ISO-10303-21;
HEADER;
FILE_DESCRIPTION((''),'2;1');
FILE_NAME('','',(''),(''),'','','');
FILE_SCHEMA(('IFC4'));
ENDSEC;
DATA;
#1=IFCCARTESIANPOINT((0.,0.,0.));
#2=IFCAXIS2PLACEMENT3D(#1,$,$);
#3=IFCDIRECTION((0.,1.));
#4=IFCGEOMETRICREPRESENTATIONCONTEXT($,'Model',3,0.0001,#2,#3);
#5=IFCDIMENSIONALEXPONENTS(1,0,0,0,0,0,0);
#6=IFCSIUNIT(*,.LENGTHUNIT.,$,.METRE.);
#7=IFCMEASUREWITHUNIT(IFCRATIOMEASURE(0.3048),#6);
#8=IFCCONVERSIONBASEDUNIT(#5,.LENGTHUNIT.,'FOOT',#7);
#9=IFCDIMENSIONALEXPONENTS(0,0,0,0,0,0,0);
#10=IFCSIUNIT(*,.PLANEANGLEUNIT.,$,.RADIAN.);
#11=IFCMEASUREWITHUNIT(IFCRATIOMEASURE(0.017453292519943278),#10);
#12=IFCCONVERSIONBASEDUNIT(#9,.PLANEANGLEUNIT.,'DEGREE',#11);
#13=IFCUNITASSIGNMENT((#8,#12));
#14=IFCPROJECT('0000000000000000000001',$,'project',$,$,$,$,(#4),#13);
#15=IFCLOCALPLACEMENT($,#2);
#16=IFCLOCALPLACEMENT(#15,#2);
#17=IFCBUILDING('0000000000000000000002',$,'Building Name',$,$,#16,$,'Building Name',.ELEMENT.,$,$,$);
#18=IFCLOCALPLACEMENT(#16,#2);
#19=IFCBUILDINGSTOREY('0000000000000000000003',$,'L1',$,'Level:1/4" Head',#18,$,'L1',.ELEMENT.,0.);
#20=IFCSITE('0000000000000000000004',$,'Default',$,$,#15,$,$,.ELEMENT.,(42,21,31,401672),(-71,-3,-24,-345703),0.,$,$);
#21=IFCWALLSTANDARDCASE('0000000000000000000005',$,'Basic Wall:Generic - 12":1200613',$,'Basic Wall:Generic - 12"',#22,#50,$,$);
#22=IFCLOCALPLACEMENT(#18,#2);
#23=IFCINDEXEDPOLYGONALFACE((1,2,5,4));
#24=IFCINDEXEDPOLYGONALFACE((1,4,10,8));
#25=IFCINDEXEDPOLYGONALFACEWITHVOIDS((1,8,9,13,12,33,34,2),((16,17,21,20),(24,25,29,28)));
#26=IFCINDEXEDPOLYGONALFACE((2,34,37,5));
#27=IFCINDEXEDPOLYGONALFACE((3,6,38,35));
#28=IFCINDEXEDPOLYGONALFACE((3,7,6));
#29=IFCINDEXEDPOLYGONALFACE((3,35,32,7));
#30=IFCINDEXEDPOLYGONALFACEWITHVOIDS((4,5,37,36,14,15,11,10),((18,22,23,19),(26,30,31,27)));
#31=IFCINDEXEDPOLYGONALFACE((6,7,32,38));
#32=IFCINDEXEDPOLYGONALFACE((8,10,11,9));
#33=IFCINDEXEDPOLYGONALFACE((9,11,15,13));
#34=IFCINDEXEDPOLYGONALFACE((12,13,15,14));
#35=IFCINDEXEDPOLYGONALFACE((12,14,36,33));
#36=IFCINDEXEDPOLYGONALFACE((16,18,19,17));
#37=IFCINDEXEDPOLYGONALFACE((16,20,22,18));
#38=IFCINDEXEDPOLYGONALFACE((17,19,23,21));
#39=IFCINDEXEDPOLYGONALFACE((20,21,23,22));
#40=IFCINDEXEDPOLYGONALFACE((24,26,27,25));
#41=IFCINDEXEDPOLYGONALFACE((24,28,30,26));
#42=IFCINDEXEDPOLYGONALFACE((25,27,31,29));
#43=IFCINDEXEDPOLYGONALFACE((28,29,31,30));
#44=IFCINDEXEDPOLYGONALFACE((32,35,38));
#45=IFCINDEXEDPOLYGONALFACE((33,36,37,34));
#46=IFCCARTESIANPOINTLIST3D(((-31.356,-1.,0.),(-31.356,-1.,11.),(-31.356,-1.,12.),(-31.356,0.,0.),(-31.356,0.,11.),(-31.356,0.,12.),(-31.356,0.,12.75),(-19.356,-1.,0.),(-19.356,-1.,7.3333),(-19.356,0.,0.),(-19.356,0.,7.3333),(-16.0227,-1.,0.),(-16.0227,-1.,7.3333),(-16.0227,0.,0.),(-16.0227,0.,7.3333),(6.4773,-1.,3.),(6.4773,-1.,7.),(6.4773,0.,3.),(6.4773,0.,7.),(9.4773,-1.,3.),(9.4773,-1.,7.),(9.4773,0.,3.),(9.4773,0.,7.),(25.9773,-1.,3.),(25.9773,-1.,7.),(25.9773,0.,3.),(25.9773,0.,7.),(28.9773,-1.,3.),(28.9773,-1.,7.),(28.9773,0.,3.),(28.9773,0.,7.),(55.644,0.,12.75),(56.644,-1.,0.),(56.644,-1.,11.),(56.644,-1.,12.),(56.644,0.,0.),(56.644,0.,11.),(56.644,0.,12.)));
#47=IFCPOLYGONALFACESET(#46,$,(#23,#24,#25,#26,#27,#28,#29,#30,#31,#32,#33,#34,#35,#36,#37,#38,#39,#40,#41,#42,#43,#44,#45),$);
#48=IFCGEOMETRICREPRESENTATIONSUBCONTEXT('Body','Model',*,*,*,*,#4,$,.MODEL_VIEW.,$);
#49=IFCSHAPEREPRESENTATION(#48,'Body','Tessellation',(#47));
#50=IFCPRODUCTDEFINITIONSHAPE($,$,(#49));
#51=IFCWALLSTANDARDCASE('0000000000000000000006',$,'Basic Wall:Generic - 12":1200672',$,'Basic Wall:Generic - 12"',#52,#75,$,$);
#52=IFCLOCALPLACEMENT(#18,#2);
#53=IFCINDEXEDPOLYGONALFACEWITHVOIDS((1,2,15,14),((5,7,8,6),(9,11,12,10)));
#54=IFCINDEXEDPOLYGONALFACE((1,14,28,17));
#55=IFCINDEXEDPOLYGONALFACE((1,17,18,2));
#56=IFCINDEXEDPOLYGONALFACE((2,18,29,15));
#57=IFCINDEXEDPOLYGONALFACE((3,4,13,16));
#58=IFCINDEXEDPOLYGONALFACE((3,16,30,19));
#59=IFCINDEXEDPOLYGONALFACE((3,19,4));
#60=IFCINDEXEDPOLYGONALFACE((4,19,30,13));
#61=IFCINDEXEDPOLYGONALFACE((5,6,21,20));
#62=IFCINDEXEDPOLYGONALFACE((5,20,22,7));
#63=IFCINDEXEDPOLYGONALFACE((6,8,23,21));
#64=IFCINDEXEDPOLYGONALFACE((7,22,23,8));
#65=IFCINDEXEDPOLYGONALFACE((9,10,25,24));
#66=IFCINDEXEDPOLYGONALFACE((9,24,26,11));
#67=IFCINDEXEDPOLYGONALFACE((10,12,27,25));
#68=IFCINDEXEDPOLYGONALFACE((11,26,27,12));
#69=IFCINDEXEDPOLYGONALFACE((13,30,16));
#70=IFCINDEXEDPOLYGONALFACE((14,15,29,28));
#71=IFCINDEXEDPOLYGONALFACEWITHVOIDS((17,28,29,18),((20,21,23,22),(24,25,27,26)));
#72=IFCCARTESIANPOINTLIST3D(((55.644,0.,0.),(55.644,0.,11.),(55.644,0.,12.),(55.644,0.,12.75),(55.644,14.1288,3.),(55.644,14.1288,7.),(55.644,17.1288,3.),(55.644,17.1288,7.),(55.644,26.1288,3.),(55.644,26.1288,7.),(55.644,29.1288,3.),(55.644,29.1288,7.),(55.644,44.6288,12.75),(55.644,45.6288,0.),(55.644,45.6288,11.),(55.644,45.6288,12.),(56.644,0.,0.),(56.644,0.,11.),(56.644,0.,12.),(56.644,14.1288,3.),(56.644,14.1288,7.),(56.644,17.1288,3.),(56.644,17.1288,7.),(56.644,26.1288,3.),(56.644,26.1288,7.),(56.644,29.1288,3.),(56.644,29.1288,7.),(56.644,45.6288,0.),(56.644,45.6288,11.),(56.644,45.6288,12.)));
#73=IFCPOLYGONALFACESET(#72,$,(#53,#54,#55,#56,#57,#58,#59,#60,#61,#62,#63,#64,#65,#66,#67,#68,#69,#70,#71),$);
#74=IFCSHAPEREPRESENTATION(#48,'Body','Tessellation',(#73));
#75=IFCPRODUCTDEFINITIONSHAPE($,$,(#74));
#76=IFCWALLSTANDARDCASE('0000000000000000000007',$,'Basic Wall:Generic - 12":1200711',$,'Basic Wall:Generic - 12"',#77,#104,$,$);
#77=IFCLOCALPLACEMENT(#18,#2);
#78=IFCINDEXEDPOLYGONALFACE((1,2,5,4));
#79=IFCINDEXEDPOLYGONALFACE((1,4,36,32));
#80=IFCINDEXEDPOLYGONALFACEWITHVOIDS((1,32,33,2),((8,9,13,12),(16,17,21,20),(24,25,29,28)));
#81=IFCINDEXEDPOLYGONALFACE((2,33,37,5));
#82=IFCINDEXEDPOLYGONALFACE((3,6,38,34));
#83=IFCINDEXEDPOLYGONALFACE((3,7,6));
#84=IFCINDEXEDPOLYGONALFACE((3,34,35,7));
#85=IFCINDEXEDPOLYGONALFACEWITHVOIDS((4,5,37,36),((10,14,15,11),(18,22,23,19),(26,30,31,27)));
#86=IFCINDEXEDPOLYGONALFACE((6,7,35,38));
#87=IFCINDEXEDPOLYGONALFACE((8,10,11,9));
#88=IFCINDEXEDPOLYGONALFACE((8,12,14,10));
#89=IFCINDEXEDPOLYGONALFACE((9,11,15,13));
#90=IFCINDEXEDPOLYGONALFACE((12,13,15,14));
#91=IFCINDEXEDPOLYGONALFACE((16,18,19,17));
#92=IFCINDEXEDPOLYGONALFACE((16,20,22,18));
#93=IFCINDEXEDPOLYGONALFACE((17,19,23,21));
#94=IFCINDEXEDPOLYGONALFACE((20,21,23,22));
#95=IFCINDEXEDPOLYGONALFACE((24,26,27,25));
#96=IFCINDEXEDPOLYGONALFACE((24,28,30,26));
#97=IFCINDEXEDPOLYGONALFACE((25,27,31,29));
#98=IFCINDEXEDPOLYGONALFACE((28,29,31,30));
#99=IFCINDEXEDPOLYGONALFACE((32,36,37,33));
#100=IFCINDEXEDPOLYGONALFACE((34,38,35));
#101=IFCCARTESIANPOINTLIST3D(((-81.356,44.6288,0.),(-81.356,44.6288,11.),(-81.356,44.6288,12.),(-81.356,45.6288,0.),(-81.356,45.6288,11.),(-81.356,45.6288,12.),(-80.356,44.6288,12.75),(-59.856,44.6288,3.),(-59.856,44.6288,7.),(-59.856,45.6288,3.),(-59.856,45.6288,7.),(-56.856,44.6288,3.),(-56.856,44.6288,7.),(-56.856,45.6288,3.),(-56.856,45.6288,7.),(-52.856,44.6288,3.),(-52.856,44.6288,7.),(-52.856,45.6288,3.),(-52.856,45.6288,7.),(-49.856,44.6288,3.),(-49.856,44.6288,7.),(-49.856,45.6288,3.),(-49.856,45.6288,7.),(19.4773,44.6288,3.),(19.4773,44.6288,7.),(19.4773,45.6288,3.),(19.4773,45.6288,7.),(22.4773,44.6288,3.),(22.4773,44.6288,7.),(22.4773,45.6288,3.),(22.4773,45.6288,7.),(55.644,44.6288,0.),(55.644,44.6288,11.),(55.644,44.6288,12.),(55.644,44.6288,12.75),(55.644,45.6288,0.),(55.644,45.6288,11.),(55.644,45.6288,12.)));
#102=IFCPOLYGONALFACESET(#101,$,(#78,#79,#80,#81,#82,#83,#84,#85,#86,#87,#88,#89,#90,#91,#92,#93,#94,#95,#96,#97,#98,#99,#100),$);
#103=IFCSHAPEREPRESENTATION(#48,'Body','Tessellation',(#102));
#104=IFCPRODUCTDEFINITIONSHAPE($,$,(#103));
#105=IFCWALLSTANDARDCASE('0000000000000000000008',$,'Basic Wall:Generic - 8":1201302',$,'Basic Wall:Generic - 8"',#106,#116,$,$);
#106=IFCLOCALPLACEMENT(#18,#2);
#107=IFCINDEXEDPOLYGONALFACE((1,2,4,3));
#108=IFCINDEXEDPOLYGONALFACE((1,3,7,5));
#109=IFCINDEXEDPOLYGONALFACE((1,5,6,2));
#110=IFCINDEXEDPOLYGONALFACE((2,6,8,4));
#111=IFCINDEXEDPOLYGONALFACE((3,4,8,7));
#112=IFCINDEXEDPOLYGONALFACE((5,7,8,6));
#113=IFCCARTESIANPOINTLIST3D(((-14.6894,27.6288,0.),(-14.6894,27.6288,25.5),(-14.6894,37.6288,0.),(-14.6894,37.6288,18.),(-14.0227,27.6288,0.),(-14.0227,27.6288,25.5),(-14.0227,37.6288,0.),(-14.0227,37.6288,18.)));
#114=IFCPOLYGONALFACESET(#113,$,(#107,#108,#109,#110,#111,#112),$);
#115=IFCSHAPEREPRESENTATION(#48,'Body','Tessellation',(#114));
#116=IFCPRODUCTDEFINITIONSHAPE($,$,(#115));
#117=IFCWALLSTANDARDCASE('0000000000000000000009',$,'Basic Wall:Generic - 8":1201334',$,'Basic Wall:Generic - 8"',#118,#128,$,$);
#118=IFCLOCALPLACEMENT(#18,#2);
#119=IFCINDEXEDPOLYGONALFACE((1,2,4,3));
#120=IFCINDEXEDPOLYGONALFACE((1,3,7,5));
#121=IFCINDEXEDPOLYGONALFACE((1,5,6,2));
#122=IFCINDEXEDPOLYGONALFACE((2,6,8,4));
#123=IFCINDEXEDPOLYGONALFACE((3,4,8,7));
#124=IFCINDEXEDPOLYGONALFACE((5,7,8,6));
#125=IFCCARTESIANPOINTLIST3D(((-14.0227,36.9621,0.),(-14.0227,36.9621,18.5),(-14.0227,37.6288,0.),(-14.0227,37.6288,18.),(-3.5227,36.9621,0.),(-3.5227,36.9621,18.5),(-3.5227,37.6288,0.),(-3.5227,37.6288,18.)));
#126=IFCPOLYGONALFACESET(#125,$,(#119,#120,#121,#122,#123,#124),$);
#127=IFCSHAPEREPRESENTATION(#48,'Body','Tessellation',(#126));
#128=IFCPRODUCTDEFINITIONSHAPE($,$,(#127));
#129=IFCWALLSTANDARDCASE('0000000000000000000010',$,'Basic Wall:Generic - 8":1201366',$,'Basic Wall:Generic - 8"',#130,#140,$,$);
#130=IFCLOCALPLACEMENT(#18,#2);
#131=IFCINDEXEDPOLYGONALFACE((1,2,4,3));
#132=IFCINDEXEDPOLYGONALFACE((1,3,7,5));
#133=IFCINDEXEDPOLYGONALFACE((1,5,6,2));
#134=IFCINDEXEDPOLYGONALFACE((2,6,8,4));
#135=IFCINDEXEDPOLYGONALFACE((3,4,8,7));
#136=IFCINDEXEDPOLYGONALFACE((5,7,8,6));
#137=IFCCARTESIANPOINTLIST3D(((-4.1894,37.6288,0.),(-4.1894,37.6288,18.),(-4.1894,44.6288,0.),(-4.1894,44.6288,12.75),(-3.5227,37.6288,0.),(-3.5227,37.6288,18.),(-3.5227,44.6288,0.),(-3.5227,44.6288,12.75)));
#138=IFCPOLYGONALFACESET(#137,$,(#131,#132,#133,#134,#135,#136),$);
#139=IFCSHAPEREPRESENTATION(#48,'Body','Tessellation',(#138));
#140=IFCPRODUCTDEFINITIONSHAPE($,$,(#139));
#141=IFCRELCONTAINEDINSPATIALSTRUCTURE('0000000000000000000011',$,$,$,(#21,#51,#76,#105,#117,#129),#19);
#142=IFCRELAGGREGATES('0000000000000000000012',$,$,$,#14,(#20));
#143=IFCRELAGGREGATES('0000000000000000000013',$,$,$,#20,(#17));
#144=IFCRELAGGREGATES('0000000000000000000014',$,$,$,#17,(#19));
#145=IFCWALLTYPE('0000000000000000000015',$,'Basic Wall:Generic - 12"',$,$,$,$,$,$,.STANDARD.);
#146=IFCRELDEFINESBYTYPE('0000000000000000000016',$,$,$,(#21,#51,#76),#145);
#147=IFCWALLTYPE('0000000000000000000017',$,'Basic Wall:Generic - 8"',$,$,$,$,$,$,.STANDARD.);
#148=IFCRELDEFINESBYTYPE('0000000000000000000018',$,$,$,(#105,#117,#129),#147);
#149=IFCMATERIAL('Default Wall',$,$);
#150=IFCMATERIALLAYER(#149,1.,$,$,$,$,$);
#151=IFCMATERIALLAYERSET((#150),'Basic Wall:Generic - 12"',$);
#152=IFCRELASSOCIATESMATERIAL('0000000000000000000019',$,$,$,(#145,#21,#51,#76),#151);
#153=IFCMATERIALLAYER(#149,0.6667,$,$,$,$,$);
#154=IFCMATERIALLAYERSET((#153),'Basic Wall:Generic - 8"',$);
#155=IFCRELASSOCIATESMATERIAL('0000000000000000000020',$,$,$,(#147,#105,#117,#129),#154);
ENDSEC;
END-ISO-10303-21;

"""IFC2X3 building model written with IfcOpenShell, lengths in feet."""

from ifc_helpers import new_model, entity, si_unit, converted_unit, direction, frame, frame_2d, origin, place, context, subcontext, project, spatial, polyline, rectangle, extrude, clip, bounded_halfspace, material, layer, layer_set, layer_usage, type_object, element, save


model = new_model("IFC2X3")

# Units and contexts
model_context = context("Model", 3, precision=0.0001, world=origin(), true_north=direction((0.0, 1.0)))
body_context = subcontext(model_context, "Body", "Model", "MODEL_VIEW")
ifc_project = project(units=[converted_unit("LENGTHUNIT", "FOOT", entity("IfcRatioMeasure", 0.3048), si_unit("LENGTHUNIT", "METRE"), dimensions=[1, 0, 0, 0, 0, 0, 0]), converted_unit("PLANEANGLEUNIT", "DEGREE", entity("IfcRatioMeasure", 0.017453292519943278), si_unit("PLANEANGLEUNIT", "RADIAN"), dimensions=[0, 0, 0, 0, 0, 0, 0])], contexts=[model_context])

# Site, building, storey
site_placement = place(None, origin())
site = spatial("IfcSite", under=ifc_project, at=site_placement, Name="Default", CompositionType="ELEMENT", RefLatitude=(42, 21, 31, 401672), RefLongitude=(-71, -3, -24, -345703), RefElevation=0.0)
building_placement = place(site_placement, origin())
building = spatial("IfcBuilding", under=site, at=building_placement, Name="Building Name", LongName="Building Name", CompositionType="ELEMENT")
storey_placement = place(building_placement, origin())
storey = spatial("IfcBuildingStorey", under=building, at=storey_placement, Name="L1", ObjectType="Level:1/4\" Head", LongName="L1", CompositionType="ELEMENT", Elevation=0.0)

# Walls, openings
ifc_material_1 = material(Name="Default Wall")
ifc_layer_1 = layer(ifc_material_1, 1.0)
ifc_layer_set_1 = layer_set([ifc_layer_1], Name="Basic Wall:Generic - 12\"")
ifc_layer_usage_1 = layer_usage(ifc_layer_set_1, "AXIS2", "NEGATIVE", 0.5)
wall_type_1 = type_object("IfcWallType", Name="Basic Wall:Generic - 12\"", PredefinedType="STANDARD", material=ifc_layer_set_1)
wall_1_placement = place(storey_placement, frame((-31.356, -0.5, 0.0)))
wall_1 = element("IfcWallStandardCase", 1, at=wall_1_placement, inside=storey, type_object=wall_type_1, material=ifc_layer_usage_1, Name="Basic Wall:Generic - 12\":1200613", ObjectType="Basic Wall:Generic - 12\"", context=body_context, shape_type="Clipping", body=[
    clip(clip(extrude(rectangle(XDim=1.0, YDim=88.0, at=frame_2d((44.0, 0.0), x_axis=(0.0, 1.0))), origin(), (0.0, 0.0, 1.0), 12.75), bounded_halfspace(frame((0.0, 0.5, 12.75), z_axis=(0.0, -0.6, 0.8), x_axis=(1.0, 0.0, 0.0)), False, frame((0.0, 0.5, 12.75)), polyline([(0.0, 0.0), (0.0, -1.0), (88.0, -1.0), (87.0, 0.0), (0.0, 0.0)]))), bounded_halfspace(frame((88.0, 0.5, 12.0), z_axis=(0.6, 0.0, 0.8), x_axis=(0.0, 1.0, 0.0)), False, frame((88.0, 0.5, 12.0)), polyline([(0.0, 0.0), (-1.0, 0.0), (0.0, -1.0), (0.0, 0.0)]))),
])
opening_1_placement = place(storey_placement, frame((-31.356, -0.5, 0.0)))
element("IfcOpeningElement", 2, at=opening_1_placement, cuts=wall_1, ObjectType="Opening", context=body_context, shape_type="SweptSolid", body=[
    extrude(rectangle(XDim=88.0, YDim=1.0, at=frame_2d((-8.6, -0.1), x_axis=(1.0, 0.0))), frame((52.6, 0.1, 11.0)), (0.0, 0.0, 1.0), 1.0),
])
opening_2_placement = place(wall_1_placement, frame((12.0, -0.5, 0.0)))
element("IfcOpeningElement", 3, at=opening_2_placement, cuts=wall_1, ObjectType="Opening", context=body_context, shape_type="SweptSolid", body=[
    extrude(rectangle(XDim=7.3333, YDim=3.3333, at=frame_2d((3.6667, 1.6667), x_axis=(1.0, 0.0))), frame((0.0, 0.0, 0.0), z_axis=(0.0, 1.0, 0.0), x_axis=(0.0, 0.0, 1.0)), (0.0, 0.0, 1.0), 1.0),
])
opening_3_placement = place(wall_1_placement, frame((37.8333, -0.5, 3.0)))
element("IfcOpeningElement", 4, at=opening_3_placement, cuts=wall_1, ObjectType="Opening", context=body_context, shape_type="SweptSolid", body=[
    extrude(rectangle(XDim=4.0, YDim=3.0, at=frame_2d((2.0, 1.5), x_axis=(-1.0, 0.0))), frame((0.0, 0.0, 0.0), z_axis=(0.0, 1.0, 0.0), x_axis=(0.0, 0.0, 1.0)), (0.0, 0.0, 1.0), 1.0),
])
opening_4_placement = place(wall_1_placement, frame((60.3333, 0.5, 3.0)))
element("IfcOpeningElement", 5, at=opening_4_placement, cuts=wall_1, ObjectType="Opening", context=body_context, shape_type="SweptSolid", body=[
    extrude(rectangle(XDim=4.0, YDim=3.0, at=frame_2d((2.0, 1.5), x_axis=(-1.0, 0.0))), frame((0.0, 0.0, 0.0), z_axis=(0.0, -1.0, 0.0), x_axis=(0.0, 0.0, 1.0)), (0.0, 0.0, 1.0), 1.0),
])
wall_2_placement = place(storey_placement, frame((56.144, 0.0, 0.0), z_axis=(0.0, 0.0, 1.0), x_axis=(0.0, 1.0, 0.0)))
wall_2 = element("IfcWallStandardCase", 6, at=wall_2_placement, inside=storey, type_object=wall_type_1, material=ifc_layer_usage_1, Name="Basic Wall:Generic - 12\":1200672", ObjectType="Basic Wall:Generic - 12\"", context=body_context, shape_type="Clipping", body=[
    clip(clip(extrude(rectangle(XDim=45.6288, YDim=1.0, at=frame_2d((22.8144, 0.0), x_axis=(-1.0, 0.0))), origin(), (0.0, 0.0, 1.0), 12.75), bounded_halfspace(frame((0.0, 0.5, 12.75), z_axis=(0.0, -0.6, 0.8), x_axis=(1.0, 0.0, 0.0)), False, frame((0.0, 0.5, 12.75)), polyline([(0.0, 0.0), (0.0, -1.0), (45.6288, -1.0), (44.6288, 0.0), (0.0, 0.0)]))), bounded_halfspace(frame((45.6288, 0.5, 12.0), z_axis=(0.6, 0.0, 0.8), x_axis=(0.0, 1.0, 0.0)), False, frame((45.6288, 0.5, 12.0)), polyline([(0.0, 0.0), (-1.0, 0.0), (0.0, -1.0), (0.0, 0.0)]))),
])
opening_5_placement = place(storey_placement, frame((56.144, 0.0, 0.0), z_axis=(0.0, 0.0, 1.0), x_axis=(0.0, 1.0, 0.0)))
element("IfcOpeningElement", 7, at=opening_5_placement, cuts=wall_2, ObjectType="Opening", context=body_context, shape_type="SweptSolid", body=[
    extrude(rectangle(XDim=45.6288, YDim=1.0, at=frame_2d((-4.3629, -0.1), x_axis=(1.0, 0.0))), frame((27.1773, 0.1, 11.0)), (0.0, 0.0, 1.0), 1.0),
])
opening_6_placement = place(wall_2_placement, frame((29.1288, 0.5, 3.0)))
element("IfcOpeningElement", 8, at=opening_6_placement, cuts=wall_2, ObjectType="Opening", context=body_context, shape_type="SweptSolid", body=[
    extrude(rectangle(XDim=4.0, YDim=3.0, at=frame_2d((2.0, 1.5), x_axis=(-1.0, 0.0))), frame((0.0, 0.0, 0.0), z_axis=(0.0, -1.0, 0.0), x_axis=(0.0, 0.0, 1.0)), (0.0, 0.0, 1.0), 1.0),
])
opening_7_placement = place(wall_2_placement, frame((14.1288, -0.5, 3.0)))
element("IfcOpeningElement", 9, at=opening_7_placement, cuts=wall_2, ObjectType="Opening", context=body_context, shape_type="SweptSolid", body=[
    extrude(rectangle(XDim=4.0, YDim=3.0, at=frame_2d((2.0, 1.5), x_axis=(-1.0, 0.0))), frame((0.0, 0.0, 0.0), z_axis=(0.0, 1.0, 0.0), x_axis=(0.0, 0.0, 1.0)), (0.0, 0.0, 1.0), 1.0),
])
wall_3_placement = place(storey_placement, frame((55.644, 45.1288, 0.0), z_axis=(0.0, 0.0, 1.0), x_axis=(-1.0, 0.0, 0.0)))
wall_3 = element("IfcWallStandardCase", 10, at=wall_3_placement, inside=storey, type_object=wall_type_1, material=ifc_layer_usage_1, Name="Basic Wall:Generic - 12\":1200711", ObjectType="Basic Wall:Generic - 12\"", context=body_context, shape_type="Clipping", body=[
    clip(clip(extrude(rectangle(XDim=137.0, YDim=1.0, at=frame_2d((68.5, 0.0), x_axis=(-1.0, 0.0))), origin(), (0.0, 0.0, 1.0), 12.75), bounded_halfspace(frame((137.0, 0.5, 12.0), z_axis=(0.6, 0.0, 0.8), x_axis=(0.0, 1.0, 0.0)), False, frame((137.0, 0.5, 12.0)), polyline([(0.0, 0.0), (-1.0, 0.0), (0.0, -1.0), (0.0, 0.0)]))), bounded_halfspace(frame((0.0, 0.5, 12.75), z_axis=(0.0, -0.6, 0.8), x_axis=(1.0, 0.0, 0.0)), False, frame((0.0, 0.5, 12.75)), polyline([(0.0, 0.0), (0.0, -1.0), (137.0, -1.0), (136.0, 0.0), (88.0, 0.0), (87.3333, 0.0), (59.8333, 0.0), (59.1667, 0.0), (0.0, 0.0)]))),
])
opening_8_placement = place(storey_placement, frame((55.644, 45.1288, 0.0), z_axis=(0.0, 0.0, 1.0), x_axis=(-1.0, 0.0, 0.0)))
element("IfcOpeningElement", 11, at=opening_8_placement, cuts=wall_3, ObjectType="Opening", context=body_context, shape_type="SweptSolid", body=[
    extrude(rectangle(XDim=137.0, YDim=1.0, at=frame_2d((-13.5, -0.1), x_axis=(1.0, 0.0))), frame((82.0, 0.1, 11.0)), (0.0, 0.0, 1.0), 1.0),
])
opening_9_placement = place(wall_3_placement, frame((33.1667, -0.5, 3.0)))
element("IfcOpeningElement", 12, at=opening_9_placement, cuts=wall_3, ObjectType="Opening", context=body_context, shape_type="SweptSolid", body=[
    extrude(rectangle(XDim=4.0, YDim=3.0, at=frame_2d((2.0, 1.5), x_axis=(-1.0, 0.0))), frame((0.0, 0.0, 0.0), z_axis=(0.0, 1.0, 0.0), x_axis=(0.0, 0.0, 1.0)), (0.0, 0.0, 1.0), 1.0),
])
opening_10_placement = place(wall_3_placement, frame((105.5, -0.5, 3.0)))
element("IfcOpeningElement", 13, at=opening_10_placement, cuts=wall_3, ObjectType="Opening", context=body_context, shape_type="SweptSolid", body=[
    extrude(rectangle(XDim=4.0, YDim=3.0, at=frame_2d((2.0, 1.5), x_axis=(-1.0, 0.0))), frame((0.0, 0.0, 0.0), z_axis=(0.0, 1.0, 0.0), x_axis=(0.0, 0.0, 1.0)), (0.0, 0.0, 1.0), 1.0),
])
opening_11_placement = place(wall_3_placement, frame((112.5, -0.5, 3.0)))
element("IfcOpeningElement", 14, at=opening_11_placement, cuts=wall_3, ObjectType="Opening", context=body_context, shape_type="SweptSolid", body=[
    extrude(rectangle(XDim=4.0, YDim=3.0, at=frame_2d((2.0, 1.5), x_axis=(-1.0, 0.0))), frame((0.0, 0.0, 0.0), z_axis=(0.0, 1.0, 0.0), x_axis=(0.0, 0.0, 1.0)), (0.0, 0.0, 1.0), 1.0),
])

# Walls
ifc_layer_2 = layer(ifc_material_1, 0.6667)
ifc_layer_set_2 = layer_set([ifc_layer_2], Name="Basic Wall:Generic - 8\"")
ifc_layer_usage_2 = layer_usage(ifc_layer_set_2, "AXIS2", "NEGATIVE", 0.3333)
wall_type_2 = type_object("IfcWallType", Name="Basic Wall:Generic - 8\"", PredefinedType="STANDARD", material=ifc_layer_set_2)
wall_4_placement = place(storey_placement, frame((-14.356, 27.6288, 0.0), z_axis=(0.0, 0.0, 1.0), x_axis=(0.0, 1.0, 0.0)))
element("IfcWallStandardCase", 15, at=wall_4_placement, inside=storey, type_object=wall_type_2, material=ifc_layer_usage_2, Name="Basic Wall:Generic - 8\":1201302", ObjectType="Basic Wall:Generic - 8\"", context=body_context, shape_type="Clipping", body=[
    clip(extrude(rectangle(XDim=10.0, YDim=0.6667, at=frame_2d((5.0, 0.0), x_axis=(-1.0, 0.0))), origin(), (0.0, 0.0, 1.0), 25.5), bounded_halfspace(frame((0.0, -0.3333, 25.5), z_axis=(0.6, 0.0, 0.8), x_axis=(0.0, 1.0, 0.0)), False, frame((0.0, -0.3333, 25.5)), polyline([(0.0, 0.0), (9.3333, 0.0), (10.0, 0.0), (10.0, 0.6667), (0.0, 0.6667), (0.0, 0.0)]))),
])
wall_5_placement = place(storey_placement, frame((-14.0227, 37.2955, 0.0)))
element("IfcWallStandardCase", 16, at=wall_5_placement, inside=storey, type_object=wall_type_2, material=ifc_layer_usage_2, Name="Basic Wall:Generic - 8\":1201334", ObjectType="Basic Wall:Generic - 8\"", context=body_context, shape_type="Clipping", body=[
    clip(extrude(rectangle(XDim=10.5, YDim=0.6667, at=frame_2d((5.25, 0.0), x_axis=(-1.0, 0.0))), origin(), (0.0, 0.0, 1.0), 18.5), bounded_halfspace(frame((0.0, -0.3333, 18.5), z_axis=(0.0, 0.6, 0.8), x_axis=(-1.0, 0.0, 0.0)), False, frame((0.0, -0.3333, 18.5)), polyline([(0.0, 0.0), (10.5, 0.0), (10.5, 0.6667), (9.8333, 0.6667), (0.0, 0.6667), (0.0, 0.0)]))),
])
wall_6_placement = place(storey_placement, frame((-3.856, 37.6288, 0.0), z_axis=(0.0, 0.0, 1.0), x_axis=(0.0, 1.0, 0.0)))
element("IfcWallStandardCase", 17, at=wall_6_placement, inside=storey, type_object=wall_type_2, material=ifc_layer_usage_2, Name="Basic Wall:Generic - 8\":1201366", ObjectType="Basic Wall:Generic - 8\"", context=body_context, shape_type="Clipping", body=[
    clip(extrude(rectangle(XDim=7.0, YDim=0.6667, at=frame_2d((3.5, 0.0), x_axis=(-1.0, 0.0))), origin(), (0.0, 0.0, 1.0), 18.0), bounded_halfspace(frame((0.0, -0.3333, 18.0), z_axis=(0.6, 0.0, 0.8), x_axis=(0.0, 1.0, 0.0)), False, frame((0.0, -0.3333, 18.0)), polyline([(0.0, 0.0), (7.0, 0.0), (7.0, 0.6667), (0.0, 0.6667), (0.0, 0.0)]))),
])

save(model, "model.ifc")
